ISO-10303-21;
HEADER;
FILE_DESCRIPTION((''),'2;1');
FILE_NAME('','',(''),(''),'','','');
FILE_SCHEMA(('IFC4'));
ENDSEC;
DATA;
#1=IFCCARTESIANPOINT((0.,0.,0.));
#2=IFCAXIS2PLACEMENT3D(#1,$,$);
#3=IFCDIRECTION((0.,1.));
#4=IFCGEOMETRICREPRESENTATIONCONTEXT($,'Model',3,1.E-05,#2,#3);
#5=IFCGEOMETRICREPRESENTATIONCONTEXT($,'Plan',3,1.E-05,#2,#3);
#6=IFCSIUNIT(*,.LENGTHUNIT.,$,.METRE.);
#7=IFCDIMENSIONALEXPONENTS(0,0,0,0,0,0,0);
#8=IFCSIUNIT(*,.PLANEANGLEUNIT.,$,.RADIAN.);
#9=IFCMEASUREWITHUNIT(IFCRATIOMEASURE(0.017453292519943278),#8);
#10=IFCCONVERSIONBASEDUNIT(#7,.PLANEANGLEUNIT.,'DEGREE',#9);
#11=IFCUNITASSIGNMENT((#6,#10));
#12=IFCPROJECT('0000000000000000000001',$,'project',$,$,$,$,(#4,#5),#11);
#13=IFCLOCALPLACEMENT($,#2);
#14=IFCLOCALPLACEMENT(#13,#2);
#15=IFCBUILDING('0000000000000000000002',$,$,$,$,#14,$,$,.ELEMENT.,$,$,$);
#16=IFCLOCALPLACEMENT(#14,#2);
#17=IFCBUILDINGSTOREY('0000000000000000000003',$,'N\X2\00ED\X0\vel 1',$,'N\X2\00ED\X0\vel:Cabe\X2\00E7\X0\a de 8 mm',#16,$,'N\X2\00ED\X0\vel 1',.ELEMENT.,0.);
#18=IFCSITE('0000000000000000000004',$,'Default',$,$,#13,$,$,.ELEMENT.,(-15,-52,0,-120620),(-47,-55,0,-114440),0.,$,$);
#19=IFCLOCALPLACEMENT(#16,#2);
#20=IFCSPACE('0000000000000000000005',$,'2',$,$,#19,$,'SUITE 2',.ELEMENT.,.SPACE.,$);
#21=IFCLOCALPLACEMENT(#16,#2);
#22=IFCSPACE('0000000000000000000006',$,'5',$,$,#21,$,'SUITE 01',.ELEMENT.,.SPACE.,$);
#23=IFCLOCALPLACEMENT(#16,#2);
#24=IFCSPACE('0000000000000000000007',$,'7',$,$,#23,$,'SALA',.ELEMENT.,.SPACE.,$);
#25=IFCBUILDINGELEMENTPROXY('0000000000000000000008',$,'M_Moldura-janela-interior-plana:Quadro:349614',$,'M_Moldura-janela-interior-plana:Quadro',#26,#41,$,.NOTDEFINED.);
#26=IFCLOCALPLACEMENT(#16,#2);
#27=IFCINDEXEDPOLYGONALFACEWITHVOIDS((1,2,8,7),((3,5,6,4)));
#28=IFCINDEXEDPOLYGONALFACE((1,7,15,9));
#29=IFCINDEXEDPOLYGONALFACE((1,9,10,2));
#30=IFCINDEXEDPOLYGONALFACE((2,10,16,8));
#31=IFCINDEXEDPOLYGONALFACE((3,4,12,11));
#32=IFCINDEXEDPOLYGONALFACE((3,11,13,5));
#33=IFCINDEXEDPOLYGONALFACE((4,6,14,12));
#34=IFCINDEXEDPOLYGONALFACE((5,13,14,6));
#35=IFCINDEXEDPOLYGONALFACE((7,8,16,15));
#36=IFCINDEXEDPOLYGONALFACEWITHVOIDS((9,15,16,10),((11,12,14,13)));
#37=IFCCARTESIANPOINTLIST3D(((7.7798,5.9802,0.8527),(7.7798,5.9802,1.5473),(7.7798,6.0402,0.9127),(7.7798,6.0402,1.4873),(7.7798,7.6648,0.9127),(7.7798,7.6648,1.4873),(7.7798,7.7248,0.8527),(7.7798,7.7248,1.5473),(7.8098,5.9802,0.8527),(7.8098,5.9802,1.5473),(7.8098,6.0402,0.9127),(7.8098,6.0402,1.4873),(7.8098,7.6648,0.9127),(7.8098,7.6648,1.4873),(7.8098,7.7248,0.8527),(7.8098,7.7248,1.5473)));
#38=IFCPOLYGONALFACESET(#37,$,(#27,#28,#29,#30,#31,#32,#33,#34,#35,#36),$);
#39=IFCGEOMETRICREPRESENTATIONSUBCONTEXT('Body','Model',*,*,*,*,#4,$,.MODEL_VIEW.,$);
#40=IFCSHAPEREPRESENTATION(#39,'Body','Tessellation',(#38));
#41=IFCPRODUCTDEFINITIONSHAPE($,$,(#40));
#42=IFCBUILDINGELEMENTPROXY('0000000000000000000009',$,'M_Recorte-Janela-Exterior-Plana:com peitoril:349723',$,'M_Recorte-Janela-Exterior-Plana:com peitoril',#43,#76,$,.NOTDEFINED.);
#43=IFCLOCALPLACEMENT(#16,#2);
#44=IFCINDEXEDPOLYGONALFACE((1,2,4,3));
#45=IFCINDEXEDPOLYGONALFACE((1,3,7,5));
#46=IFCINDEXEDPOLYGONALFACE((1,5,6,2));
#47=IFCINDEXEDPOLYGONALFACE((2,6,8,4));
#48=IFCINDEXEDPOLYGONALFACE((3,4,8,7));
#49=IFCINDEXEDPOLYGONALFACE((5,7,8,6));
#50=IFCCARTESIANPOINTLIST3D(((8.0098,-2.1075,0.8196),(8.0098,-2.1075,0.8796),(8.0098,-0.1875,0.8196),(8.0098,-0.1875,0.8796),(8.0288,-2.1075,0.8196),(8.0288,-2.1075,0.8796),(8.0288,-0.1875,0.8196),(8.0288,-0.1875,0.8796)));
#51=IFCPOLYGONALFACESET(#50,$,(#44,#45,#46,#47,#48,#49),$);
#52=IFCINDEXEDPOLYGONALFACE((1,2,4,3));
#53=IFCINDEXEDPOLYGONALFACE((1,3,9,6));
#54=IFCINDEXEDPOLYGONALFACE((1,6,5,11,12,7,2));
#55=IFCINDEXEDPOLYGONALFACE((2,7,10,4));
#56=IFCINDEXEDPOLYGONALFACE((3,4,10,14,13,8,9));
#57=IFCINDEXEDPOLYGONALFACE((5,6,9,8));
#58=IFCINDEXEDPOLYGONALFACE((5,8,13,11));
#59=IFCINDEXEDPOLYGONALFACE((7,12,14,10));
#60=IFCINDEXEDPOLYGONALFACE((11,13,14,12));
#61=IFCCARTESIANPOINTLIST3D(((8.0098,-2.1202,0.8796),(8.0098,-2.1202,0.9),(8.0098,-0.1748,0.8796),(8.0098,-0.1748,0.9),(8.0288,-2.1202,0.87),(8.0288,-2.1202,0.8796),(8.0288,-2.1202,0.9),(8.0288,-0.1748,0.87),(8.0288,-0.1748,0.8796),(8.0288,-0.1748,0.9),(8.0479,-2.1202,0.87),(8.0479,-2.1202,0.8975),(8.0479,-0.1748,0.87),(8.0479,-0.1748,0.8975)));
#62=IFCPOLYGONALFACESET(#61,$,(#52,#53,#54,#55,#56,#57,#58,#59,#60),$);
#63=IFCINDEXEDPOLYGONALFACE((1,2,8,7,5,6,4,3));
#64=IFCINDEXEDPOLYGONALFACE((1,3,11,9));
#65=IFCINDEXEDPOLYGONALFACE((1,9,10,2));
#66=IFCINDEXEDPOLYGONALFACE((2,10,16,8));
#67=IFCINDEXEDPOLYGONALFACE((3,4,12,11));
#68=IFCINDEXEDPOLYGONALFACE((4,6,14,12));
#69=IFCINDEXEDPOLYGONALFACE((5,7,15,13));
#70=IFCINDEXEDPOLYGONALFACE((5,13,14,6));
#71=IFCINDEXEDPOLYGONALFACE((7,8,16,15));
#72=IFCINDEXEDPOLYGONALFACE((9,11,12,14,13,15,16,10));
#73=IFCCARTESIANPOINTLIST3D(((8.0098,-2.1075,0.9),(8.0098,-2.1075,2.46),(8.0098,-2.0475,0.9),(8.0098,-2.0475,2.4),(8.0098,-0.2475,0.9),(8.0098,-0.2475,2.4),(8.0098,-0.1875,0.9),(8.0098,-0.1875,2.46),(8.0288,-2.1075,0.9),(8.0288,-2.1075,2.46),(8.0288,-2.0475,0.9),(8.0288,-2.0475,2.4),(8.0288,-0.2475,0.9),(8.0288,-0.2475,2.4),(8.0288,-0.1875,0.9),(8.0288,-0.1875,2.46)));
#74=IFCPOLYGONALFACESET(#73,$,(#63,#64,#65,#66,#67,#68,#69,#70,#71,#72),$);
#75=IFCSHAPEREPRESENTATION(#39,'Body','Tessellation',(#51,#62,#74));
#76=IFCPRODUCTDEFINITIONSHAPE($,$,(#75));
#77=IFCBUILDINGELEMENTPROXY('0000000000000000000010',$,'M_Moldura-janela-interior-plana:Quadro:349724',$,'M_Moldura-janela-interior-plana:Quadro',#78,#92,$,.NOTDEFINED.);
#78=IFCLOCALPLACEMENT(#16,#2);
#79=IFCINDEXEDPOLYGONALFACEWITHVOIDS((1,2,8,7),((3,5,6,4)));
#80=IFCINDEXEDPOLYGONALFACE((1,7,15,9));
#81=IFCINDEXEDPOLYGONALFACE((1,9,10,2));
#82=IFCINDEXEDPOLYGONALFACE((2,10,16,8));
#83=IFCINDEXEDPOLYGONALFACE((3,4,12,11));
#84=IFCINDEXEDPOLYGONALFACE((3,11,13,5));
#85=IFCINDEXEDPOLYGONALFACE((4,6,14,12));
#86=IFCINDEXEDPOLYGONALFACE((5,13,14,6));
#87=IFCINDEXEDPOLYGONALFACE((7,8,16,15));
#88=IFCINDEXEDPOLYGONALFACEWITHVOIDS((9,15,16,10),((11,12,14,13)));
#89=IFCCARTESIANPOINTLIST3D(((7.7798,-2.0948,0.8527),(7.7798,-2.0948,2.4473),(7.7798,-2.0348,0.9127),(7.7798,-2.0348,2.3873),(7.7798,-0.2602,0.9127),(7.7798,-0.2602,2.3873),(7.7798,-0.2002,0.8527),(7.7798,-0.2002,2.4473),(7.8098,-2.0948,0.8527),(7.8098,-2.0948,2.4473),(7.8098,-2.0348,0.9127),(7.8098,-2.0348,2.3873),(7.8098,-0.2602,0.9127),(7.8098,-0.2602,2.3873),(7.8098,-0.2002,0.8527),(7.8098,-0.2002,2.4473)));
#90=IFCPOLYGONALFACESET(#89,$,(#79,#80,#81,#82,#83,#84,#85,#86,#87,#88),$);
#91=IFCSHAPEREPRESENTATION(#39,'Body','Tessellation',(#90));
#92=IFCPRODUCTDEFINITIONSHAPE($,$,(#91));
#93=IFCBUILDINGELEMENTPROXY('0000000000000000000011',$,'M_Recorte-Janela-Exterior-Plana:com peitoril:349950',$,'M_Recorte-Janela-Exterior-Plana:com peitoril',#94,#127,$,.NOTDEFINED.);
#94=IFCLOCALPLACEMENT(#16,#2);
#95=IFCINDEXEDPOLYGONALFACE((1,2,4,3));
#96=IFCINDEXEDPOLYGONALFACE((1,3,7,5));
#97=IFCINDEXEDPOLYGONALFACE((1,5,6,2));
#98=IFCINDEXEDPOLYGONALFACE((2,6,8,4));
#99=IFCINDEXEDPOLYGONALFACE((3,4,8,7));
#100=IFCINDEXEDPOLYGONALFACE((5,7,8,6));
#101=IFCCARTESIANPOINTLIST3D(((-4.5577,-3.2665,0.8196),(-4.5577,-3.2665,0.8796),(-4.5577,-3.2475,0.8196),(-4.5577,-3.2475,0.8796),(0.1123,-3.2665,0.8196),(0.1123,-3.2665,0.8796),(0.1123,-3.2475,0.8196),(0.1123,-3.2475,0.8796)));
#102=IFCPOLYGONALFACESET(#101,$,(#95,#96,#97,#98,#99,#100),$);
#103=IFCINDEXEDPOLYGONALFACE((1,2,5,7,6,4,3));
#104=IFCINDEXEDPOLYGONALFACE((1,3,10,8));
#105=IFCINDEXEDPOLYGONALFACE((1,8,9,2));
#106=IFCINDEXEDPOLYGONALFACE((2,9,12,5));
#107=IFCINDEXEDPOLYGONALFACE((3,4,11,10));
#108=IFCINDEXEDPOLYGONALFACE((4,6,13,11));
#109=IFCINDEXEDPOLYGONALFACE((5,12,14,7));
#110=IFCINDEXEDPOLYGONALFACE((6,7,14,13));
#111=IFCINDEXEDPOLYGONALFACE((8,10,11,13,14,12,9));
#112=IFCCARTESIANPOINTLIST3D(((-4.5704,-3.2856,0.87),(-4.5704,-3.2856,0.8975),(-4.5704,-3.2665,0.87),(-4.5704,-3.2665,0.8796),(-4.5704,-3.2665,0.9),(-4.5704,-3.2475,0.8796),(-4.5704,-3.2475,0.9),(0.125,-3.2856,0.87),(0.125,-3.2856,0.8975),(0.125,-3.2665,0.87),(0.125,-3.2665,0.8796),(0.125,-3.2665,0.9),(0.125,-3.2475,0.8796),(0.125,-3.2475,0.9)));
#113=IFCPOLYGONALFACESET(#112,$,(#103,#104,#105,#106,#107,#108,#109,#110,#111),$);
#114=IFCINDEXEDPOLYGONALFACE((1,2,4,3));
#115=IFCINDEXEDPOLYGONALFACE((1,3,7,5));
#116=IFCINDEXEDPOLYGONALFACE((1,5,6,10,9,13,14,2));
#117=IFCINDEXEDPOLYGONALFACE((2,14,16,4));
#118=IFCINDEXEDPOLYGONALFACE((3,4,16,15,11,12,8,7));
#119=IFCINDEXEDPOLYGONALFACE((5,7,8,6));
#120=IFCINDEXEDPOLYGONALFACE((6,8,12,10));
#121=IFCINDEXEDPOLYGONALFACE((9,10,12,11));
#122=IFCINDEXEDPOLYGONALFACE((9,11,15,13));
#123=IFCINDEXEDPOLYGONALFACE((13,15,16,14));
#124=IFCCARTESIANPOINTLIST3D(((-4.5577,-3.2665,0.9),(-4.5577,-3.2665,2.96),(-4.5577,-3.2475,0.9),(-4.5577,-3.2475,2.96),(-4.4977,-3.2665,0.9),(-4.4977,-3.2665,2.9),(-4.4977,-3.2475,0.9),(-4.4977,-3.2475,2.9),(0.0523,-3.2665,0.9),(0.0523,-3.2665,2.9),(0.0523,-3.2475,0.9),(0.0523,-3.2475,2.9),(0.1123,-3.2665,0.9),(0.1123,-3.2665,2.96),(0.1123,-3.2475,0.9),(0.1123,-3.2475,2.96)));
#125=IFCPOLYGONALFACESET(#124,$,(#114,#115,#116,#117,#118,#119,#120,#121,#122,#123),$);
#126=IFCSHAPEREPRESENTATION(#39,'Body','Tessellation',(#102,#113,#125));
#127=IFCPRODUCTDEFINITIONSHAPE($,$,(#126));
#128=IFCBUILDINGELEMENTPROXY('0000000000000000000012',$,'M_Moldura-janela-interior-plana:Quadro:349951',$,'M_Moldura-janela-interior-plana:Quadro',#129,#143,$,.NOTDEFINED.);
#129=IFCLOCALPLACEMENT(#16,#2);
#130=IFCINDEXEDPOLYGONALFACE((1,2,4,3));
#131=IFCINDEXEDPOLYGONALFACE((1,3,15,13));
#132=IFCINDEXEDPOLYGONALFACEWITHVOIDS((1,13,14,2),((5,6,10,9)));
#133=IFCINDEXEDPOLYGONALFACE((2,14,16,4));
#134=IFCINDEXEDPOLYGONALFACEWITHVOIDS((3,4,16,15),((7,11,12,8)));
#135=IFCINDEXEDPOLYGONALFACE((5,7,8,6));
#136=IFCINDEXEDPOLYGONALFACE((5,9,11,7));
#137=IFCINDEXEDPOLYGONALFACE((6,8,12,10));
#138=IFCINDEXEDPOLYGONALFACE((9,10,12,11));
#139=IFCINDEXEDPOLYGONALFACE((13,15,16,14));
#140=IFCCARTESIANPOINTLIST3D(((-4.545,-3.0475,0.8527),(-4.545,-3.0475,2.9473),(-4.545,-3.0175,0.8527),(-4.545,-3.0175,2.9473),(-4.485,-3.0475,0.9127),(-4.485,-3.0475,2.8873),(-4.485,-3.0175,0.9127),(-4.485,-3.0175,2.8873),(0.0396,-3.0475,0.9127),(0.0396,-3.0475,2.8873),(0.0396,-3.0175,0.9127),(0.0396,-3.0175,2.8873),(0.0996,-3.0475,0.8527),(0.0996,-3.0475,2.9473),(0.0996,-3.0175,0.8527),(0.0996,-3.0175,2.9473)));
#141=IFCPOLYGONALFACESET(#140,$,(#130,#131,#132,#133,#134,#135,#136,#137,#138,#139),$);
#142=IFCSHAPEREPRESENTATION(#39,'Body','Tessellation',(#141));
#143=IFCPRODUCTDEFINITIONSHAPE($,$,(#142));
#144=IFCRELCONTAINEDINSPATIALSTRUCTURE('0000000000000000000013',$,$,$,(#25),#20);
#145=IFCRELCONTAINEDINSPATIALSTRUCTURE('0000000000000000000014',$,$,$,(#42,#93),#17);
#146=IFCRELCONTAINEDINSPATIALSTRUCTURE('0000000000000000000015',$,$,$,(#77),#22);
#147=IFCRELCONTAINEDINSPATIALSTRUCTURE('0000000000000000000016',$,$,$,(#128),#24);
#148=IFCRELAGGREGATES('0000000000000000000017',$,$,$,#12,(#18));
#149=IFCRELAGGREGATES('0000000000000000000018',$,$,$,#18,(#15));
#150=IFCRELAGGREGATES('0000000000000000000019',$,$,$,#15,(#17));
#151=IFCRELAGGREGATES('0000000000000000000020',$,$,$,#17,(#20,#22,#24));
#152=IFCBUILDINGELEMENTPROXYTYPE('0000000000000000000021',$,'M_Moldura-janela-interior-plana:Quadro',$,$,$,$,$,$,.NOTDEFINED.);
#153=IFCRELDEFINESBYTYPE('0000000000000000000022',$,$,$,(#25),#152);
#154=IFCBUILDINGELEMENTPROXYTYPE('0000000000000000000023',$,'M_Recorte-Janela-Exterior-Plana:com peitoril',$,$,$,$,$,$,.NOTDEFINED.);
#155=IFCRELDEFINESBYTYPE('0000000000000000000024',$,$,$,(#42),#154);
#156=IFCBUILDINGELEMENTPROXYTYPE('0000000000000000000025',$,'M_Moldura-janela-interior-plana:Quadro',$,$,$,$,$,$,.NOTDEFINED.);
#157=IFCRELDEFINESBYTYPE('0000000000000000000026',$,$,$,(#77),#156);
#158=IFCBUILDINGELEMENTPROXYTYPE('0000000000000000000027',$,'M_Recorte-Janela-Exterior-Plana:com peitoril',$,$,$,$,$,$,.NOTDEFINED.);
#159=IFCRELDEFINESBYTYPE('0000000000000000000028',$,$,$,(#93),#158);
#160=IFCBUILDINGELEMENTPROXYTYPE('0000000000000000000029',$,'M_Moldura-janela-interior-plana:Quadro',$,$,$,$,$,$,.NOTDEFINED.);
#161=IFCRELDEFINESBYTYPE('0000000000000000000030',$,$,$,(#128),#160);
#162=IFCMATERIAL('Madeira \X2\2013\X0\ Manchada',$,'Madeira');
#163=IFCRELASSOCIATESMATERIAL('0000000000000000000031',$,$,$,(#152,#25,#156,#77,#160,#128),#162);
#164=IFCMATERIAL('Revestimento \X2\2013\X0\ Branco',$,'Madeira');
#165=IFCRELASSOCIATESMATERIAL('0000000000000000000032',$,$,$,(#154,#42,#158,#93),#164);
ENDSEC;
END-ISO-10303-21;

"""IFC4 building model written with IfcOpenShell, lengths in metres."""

from ifc_helpers import new_model, entity, si_unit, converted_unit, direction, frame, origin, place, context, subcontext, project, spatial, indexed_curve, outline, extrude, source, transform, mapped, material, type_object, type_shapes, element, save


model = new_model("IFC4")

# Units and contexts
model_context = context("Model", 3, precision=1e-05, world=origin(), true_north=direction((0.0, 1.0)))
plan_context = context("Plan", 3, precision=1e-05, world=origin(), true_north=direction((0.0, 1.0)))
body_context = subcontext(model_context, "Body", "Model", "MODEL_VIEW")
ifc_project = project(units=[si_unit("LENGTHUNIT", "METRE"), converted_unit("PLANEANGLEUNIT", "DEGREE", entity("IfcRatioMeasure", 0.017453292519943278), si_unit("PLANEANGLEUNIT", "RADIAN"), dimensions=[0, 0, 0, 0, 0, 0, 0])], contexts=[model_context, plan_context])

# Site, building, storey
site_placement = place(None, origin())
site = spatial("IfcSite", under=ifc_project, at=site_placement, Name="Default", CompositionType="ELEMENT", RefLatitude=(-15, -52, 0, -120620), RefLongitude=(-47, -55, 0, -114440), RefElevation=0.0)
building_placement = place(site_placement, origin())
building = spatial("IfcBuilding", under=site, at=building_placement, CompositionType="ELEMENT")
storey_placement = place(building_placement, origin())
storey = spatial("IfcBuildingStorey", under=building, at=storey_placement, Name="Nível 1", ObjectType="Nível:Cabeça de 8 mm", LongName="Nível 1", CompositionType="ELEMENT", Elevation=0.0)

# Shared definitions
ifc_material_1 = material(Name="Revestimento – Branco", Category="Madeira")

# Shared definitions
ifc_material_2 = material(Name="Madeira – Manchada", Category="Madeira")

# Shared definitions
space_1_placement = place(storey_placement, origin())
space_1 = spatial("IfcSpace", under=storey, at=space_1_placement, Name="2", LongName="SUITE 2", CompositionType="ELEMENT", PredefinedType="SPACE")

# Building element proxies
building_element_proxy_type_1 = type_object("IfcBuildingElementProxyType", Name="M_Moldura-janela-interior-plana:Quadro", PredefinedType="NOTDEFINED", material=ifc_material_2)
shared_shape_1 = source(origin(), body_context, "Body", "SweptSolid", [
    extrude(outline(indexed_curve([(-0.8723, -0.3473), (0.8723, -0.3473), (0.8723, 0.3473), (-0.8723, 0.3473), (-0.8723, -0.3473)], self_intersect=False), holes=[indexed_curve([(-0.8123, -0.2873), (-0.8123, 0.2873), (0.8123, 0.2873), (0.8123, -0.2873), (-0.8123, -0.2873)], self_intersect=False)]), frame((0.0, -0.3, 0.0), z_axis=(0.0, 0.0, 1.0), x_axis=(-1.0, 0.0, 0.0)), (0.0, 0.0, 1.0), 0.03),
])
type_shapes(building_element_proxy_type_1, [shared_shape_1])
proxy_1_placement = place(space_1_placement, frame((7.8098, 6.8525, 1.5), z_axis=(-1.0, 0.0, 0.0), x_axis=(0.0, -1.0, 0.0)))
element("IfcBuildingElementProxy", 1, at=proxy_1_placement, inside=space_1, type_object=building_element_proxy_type_1, material=ifc_material_2, Name="M_Moldura-janela-interior-plana:Quadro:349614", ObjectType="M_Moldura-janela-interior-plana:Quadro", PredefinedType="NOTDEFINED", context=body_context, shape_type="MappedRepresentation", body=[
    mapped(shared_shape_1, transform((0.0, 0.0, 0.0), scale=1.0)),
])
building_element_proxy_type_2 = type_object("IfcBuildingElementProxyType", Name="M_Recorte-Janela-Exterior-Plana:com peitoril", PredefinedType="NOTDEFINED", material=ifc_material_1)
shared_shape_2 = source(origin(), body_context, "Body", "SweptSolid", [
    extrude(outline(indexed_curve([(-0.96, -0.03), (0.96, -0.03), (0.96, 0.03), (-0.96, 0.03), (-0.96, -0.03)], self_intersect=False)), frame((0.0, -1.5504, 0.0), z_axis=(0.0, 0.0, 1.0), x_axis=(-1.0, 0.0, 0.0)), (0.0, 0.0, 1.0), 0.019),
    extrude(outline(indexed_curve([(-0.019, -0.0152), (0.0, -0.0152), (0.0, -0.0057), (0.019, -0.0057), (0.019, 0.0148), (0.0, 0.0148), (-0.019, 0.0123), (-0.019, -0.0152)], self_intersect=False)), frame((-0.9727, -1.5148, 0.019), z_axis=(1.0, 0.0, 0.0), x_axis=(0.0, 0.0, -1.0)), (0.0, 0.0, 1.0), 1.9454),
    extrude(outline(indexed_curve([(-0.795, -0.96), (0.765, -0.96), (0.765, -0.9), (-0.735, -0.9), (-0.735, 0.9), (0.765, 0.9), (0.765, 0.96), (-0.795, 0.96), (-0.795, -0.96)], self_intersect=False)), frame((0.0, -0.735, 0.0), z_axis=(0.0, 0.0, 1.0), x_axis=(0.0, -1.0, 0.0)), (0.0, 0.0, 1.0), 0.019),
])
type_shapes(building_element_proxy_type_2, [shared_shape_2])
proxy_2_placement = place(storey_placement, frame((8.0098, -1.1475, 2.4), z_axis=(1.0, 0.0, 0.0), x_axis=(0.0, 1.0, 0.0)))
element("IfcBuildingElementProxy", 2, at=proxy_2_placement, inside=storey, type_object=building_element_proxy_type_2, material=ifc_material_1, Name="M_Recorte-Janela-Exterior-Plana:com peitoril:349723", ObjectType="M_Recorte-Janela-Exterior-Plana:com peitoril", PredefinedType="NOTDEFINED", context=body_context, shape_type="MappedRepresentation", body=[
    mapped(shared_shape_2, transform((0.0, 0.0, 0.0), scale=1.0)),
])

# Shared definitions
space_2_placement = place(storey_placement, origin())
space_2 = spatial("IfcSpace", under=storey, at=space_2_placement, Name="5", LongName="SUITE 01", CompositionType="ELEMENT", PredefinedType="SPACE")

# Building element proxies
building_element_proxy_type_3 = type_object("IfcBuildingElementProxyType", Name="M_Moldura-janela-interior-plana:Quadro", PredefinedType="NOTDEFINED", material=ifc_material_2)
shared_shape_3 = source(origin(), body_context, "Body", "SweptSolid", [
    extrude(outline(indexed_curve([(-0.9473, -0.7973), (0.9473, -0.7973), (0.9473, 0.7973), (-0.9473, 0.7973), (-0.9473, -0.7973)], self_intersect=False), holes=[indexed_curve([(-0.8873, -0.7373), (-0.8873, 0.7373), (0.8873, 0.7373), (0.8873, -0.7373), (-0.8873, -0.7373)], self_intersect=False)]), frame((0.0, -0.75, 0.0), z_axis=(0.0, 0.0, 1.0), x_axis=(-1.0, 0.0, 0.0)), (0.0, 0.0, 1.0), 0.03),
])
type_shapes(building_element_proxy_type_3, [shared_shape_3])
proxy_3_placement = place(space_2_placement, frame((7.8098, -1.1475, 2.4), z_axis=(-1.0, 0.0, 0.0), x_axis=(0.0, -1.0, 0.0)))
element("IfcBuildingElementProxy", 3, at=proxy_3_placement, inside=space_2, type_object=building_element_proxy_type_3, material=ifc_material_2, Name="M_Moldura-janela-interior-plana:Quadro:349724", ObjectType="M_Moldura-janela-interior-plana:Quadro", PredefinedType="NOTDEFINED", context=body_context, shape_type="MappedRepresentation", body=[
    mapped(shared_shape_3, transform((0.0, 0.0, 0.0), scale=1.0)),
])
building_element_proxy_type_4 = type_object("IfcBuildingElementProxyType", Name="M_Recorte-Janela-Exterior-Plana:com peitoril", PredefinedType="NOTDEFINED", material=ifc_material_1)
shared_shape_4 = source(origin(), body_context, "Body", "SweptSolid", [
    extrude(outline(indexed_curve([(-2.335, -0.03), (2.335, -0.03), (2.335, 0.03), (-2.335, 0.03), (-2.335, -0.03)], self_intersect=False)), frame((0.0, -2.0504, 0.0), z_axis=(0.0, 0.0, 1.0), x_axis=(-1.0, 0.0, 0.0)), (0.0, 0.0, 1.0), 0.019),
    extrude(outline(indexed_curve([(-0.019, -0.0152), (0.0, -0.0152), (0.0, -0.0057), (0.019, -0.0057), (0.019, 0.0148), (0.0, 0.0148), (-0.019, 0.0123), (-0.019, -0.0152)], self_intersect=False)), frame((-2.3477, -2.0148, 0.019), z_axis=(1.0, 0.0, 0.0), x_axis=(0.0, 0.0, -1.0)), (0.0, 0.0, 1.0), 4.6954),
    extrude(outline(indexed_curve([(-1.045, -2.335), (1.015, -2.335), (1.015, -2.275), (-0.985, -2.275), (-0.985, 2.275), (1.015, 2.275), (1.015, 2.335), (-1.045, 2.335), (-1.045, -2.335)], self_intersect=False)), frame((0.0, -0.985, 0.0), z_axis=(0.0, 0.0, 1.0), x_axis=(0.0, -1.0, 0.0)), (0.0, 0.0, 1.0), 0.019),
])
type_shapes(building_element_proxy_type_4, [shared_shape_4])
proxy_4_placement = place(storey_placement, frame((-2.2227, -3.2475, 2.9), z_axis=(0.0, -1.0, 0.0), x_axis=(1.0, 0.0, 0.0)))
element("IfcBuildingElementProxy", 4, at=proxy_4_placement, inside=storey, type_object=building_element_proxy_type_4, material=ifc_material_1, Name="M_Recorte-Janela-Exterior-Plana:com peitoril:349950", ObjectType="M_Recorte-Janela-Exterior-Plana:com peitoril", PredefinedType="NOTDEFINED", context=body_context, shape_type="MappedRepresentation", body=[
    mapped(shared_shape_4, transform((0.0, 0.0, 0.0), scale=1.0)),
])

# Shared definitions
space_3_placement = place(storey_placement, origin())
space_3 = spatial("IfcSpace", under=storey, at=space_3_placement, Name="7", LongName="SALA", CompositionType="ELEMENT", PredefinedType="SPACE")

# Building element proxy
building_element_proxy_type_5 = type_object("IfcBuildingElementProxyType", Name="M_Moldura-janela-interior-plana:Quadro", PredefinedType="NOTDEFINED", material=ifc_material_2)
shared_shape_5 = source(origin(), body_context, "Body", "SweptSolid", [
    extrude(outline(indexed_curve([(-2.3223, -1.0473), (2.3223, -1.0473), (2.3223, 1.0473), (-2.3223, 1.0473), (-2.3223, -1.0473)], self_intersect=False), holes=[indexed_curve([(-2.2623, -0.9873), (-2.2623, 0.9873), (2.2623, 0.9873), (2.2623, -0.9873), (-2.2623, -0.9873)], self_intersect=False)]), frame((0.0, -1.0, 0.0), z_axis=(0.0, 0.0, 1.0), x_axis=(-1.0, 0.0, 0.0)), (0.0, 0.0, 1.0), 0.03),
])
type_shapes(building_element_proxy_type_5, [shared_shape_5])
proxy_5_placement = place(space_3_placement, frame((-2.2227, -3.0475, 2.9), z_axis=(0.0, 1.0, 0.0), x_axis=(-1.0, 0.0, 0.0)))
element("IfcBuildingElementProxy", 5, at=proxy_5_placement, inside=space_3, type_object=building_element_proxy_type_5, material=ifc_material_2, Name="M_Moldura-janela-interior-plana:Quadro:349951", ObjectType="M_Moldura-janela-interior-plana:Quadro", PredefinedType="NOTDEFINED", context=body_context, shape_type="MappedRepresentation", body=[
    mapped(shared_shape_5, transform((0.0, 0.0, 0.0), scale=1.0)),
])

save(model, "model.ifc")
